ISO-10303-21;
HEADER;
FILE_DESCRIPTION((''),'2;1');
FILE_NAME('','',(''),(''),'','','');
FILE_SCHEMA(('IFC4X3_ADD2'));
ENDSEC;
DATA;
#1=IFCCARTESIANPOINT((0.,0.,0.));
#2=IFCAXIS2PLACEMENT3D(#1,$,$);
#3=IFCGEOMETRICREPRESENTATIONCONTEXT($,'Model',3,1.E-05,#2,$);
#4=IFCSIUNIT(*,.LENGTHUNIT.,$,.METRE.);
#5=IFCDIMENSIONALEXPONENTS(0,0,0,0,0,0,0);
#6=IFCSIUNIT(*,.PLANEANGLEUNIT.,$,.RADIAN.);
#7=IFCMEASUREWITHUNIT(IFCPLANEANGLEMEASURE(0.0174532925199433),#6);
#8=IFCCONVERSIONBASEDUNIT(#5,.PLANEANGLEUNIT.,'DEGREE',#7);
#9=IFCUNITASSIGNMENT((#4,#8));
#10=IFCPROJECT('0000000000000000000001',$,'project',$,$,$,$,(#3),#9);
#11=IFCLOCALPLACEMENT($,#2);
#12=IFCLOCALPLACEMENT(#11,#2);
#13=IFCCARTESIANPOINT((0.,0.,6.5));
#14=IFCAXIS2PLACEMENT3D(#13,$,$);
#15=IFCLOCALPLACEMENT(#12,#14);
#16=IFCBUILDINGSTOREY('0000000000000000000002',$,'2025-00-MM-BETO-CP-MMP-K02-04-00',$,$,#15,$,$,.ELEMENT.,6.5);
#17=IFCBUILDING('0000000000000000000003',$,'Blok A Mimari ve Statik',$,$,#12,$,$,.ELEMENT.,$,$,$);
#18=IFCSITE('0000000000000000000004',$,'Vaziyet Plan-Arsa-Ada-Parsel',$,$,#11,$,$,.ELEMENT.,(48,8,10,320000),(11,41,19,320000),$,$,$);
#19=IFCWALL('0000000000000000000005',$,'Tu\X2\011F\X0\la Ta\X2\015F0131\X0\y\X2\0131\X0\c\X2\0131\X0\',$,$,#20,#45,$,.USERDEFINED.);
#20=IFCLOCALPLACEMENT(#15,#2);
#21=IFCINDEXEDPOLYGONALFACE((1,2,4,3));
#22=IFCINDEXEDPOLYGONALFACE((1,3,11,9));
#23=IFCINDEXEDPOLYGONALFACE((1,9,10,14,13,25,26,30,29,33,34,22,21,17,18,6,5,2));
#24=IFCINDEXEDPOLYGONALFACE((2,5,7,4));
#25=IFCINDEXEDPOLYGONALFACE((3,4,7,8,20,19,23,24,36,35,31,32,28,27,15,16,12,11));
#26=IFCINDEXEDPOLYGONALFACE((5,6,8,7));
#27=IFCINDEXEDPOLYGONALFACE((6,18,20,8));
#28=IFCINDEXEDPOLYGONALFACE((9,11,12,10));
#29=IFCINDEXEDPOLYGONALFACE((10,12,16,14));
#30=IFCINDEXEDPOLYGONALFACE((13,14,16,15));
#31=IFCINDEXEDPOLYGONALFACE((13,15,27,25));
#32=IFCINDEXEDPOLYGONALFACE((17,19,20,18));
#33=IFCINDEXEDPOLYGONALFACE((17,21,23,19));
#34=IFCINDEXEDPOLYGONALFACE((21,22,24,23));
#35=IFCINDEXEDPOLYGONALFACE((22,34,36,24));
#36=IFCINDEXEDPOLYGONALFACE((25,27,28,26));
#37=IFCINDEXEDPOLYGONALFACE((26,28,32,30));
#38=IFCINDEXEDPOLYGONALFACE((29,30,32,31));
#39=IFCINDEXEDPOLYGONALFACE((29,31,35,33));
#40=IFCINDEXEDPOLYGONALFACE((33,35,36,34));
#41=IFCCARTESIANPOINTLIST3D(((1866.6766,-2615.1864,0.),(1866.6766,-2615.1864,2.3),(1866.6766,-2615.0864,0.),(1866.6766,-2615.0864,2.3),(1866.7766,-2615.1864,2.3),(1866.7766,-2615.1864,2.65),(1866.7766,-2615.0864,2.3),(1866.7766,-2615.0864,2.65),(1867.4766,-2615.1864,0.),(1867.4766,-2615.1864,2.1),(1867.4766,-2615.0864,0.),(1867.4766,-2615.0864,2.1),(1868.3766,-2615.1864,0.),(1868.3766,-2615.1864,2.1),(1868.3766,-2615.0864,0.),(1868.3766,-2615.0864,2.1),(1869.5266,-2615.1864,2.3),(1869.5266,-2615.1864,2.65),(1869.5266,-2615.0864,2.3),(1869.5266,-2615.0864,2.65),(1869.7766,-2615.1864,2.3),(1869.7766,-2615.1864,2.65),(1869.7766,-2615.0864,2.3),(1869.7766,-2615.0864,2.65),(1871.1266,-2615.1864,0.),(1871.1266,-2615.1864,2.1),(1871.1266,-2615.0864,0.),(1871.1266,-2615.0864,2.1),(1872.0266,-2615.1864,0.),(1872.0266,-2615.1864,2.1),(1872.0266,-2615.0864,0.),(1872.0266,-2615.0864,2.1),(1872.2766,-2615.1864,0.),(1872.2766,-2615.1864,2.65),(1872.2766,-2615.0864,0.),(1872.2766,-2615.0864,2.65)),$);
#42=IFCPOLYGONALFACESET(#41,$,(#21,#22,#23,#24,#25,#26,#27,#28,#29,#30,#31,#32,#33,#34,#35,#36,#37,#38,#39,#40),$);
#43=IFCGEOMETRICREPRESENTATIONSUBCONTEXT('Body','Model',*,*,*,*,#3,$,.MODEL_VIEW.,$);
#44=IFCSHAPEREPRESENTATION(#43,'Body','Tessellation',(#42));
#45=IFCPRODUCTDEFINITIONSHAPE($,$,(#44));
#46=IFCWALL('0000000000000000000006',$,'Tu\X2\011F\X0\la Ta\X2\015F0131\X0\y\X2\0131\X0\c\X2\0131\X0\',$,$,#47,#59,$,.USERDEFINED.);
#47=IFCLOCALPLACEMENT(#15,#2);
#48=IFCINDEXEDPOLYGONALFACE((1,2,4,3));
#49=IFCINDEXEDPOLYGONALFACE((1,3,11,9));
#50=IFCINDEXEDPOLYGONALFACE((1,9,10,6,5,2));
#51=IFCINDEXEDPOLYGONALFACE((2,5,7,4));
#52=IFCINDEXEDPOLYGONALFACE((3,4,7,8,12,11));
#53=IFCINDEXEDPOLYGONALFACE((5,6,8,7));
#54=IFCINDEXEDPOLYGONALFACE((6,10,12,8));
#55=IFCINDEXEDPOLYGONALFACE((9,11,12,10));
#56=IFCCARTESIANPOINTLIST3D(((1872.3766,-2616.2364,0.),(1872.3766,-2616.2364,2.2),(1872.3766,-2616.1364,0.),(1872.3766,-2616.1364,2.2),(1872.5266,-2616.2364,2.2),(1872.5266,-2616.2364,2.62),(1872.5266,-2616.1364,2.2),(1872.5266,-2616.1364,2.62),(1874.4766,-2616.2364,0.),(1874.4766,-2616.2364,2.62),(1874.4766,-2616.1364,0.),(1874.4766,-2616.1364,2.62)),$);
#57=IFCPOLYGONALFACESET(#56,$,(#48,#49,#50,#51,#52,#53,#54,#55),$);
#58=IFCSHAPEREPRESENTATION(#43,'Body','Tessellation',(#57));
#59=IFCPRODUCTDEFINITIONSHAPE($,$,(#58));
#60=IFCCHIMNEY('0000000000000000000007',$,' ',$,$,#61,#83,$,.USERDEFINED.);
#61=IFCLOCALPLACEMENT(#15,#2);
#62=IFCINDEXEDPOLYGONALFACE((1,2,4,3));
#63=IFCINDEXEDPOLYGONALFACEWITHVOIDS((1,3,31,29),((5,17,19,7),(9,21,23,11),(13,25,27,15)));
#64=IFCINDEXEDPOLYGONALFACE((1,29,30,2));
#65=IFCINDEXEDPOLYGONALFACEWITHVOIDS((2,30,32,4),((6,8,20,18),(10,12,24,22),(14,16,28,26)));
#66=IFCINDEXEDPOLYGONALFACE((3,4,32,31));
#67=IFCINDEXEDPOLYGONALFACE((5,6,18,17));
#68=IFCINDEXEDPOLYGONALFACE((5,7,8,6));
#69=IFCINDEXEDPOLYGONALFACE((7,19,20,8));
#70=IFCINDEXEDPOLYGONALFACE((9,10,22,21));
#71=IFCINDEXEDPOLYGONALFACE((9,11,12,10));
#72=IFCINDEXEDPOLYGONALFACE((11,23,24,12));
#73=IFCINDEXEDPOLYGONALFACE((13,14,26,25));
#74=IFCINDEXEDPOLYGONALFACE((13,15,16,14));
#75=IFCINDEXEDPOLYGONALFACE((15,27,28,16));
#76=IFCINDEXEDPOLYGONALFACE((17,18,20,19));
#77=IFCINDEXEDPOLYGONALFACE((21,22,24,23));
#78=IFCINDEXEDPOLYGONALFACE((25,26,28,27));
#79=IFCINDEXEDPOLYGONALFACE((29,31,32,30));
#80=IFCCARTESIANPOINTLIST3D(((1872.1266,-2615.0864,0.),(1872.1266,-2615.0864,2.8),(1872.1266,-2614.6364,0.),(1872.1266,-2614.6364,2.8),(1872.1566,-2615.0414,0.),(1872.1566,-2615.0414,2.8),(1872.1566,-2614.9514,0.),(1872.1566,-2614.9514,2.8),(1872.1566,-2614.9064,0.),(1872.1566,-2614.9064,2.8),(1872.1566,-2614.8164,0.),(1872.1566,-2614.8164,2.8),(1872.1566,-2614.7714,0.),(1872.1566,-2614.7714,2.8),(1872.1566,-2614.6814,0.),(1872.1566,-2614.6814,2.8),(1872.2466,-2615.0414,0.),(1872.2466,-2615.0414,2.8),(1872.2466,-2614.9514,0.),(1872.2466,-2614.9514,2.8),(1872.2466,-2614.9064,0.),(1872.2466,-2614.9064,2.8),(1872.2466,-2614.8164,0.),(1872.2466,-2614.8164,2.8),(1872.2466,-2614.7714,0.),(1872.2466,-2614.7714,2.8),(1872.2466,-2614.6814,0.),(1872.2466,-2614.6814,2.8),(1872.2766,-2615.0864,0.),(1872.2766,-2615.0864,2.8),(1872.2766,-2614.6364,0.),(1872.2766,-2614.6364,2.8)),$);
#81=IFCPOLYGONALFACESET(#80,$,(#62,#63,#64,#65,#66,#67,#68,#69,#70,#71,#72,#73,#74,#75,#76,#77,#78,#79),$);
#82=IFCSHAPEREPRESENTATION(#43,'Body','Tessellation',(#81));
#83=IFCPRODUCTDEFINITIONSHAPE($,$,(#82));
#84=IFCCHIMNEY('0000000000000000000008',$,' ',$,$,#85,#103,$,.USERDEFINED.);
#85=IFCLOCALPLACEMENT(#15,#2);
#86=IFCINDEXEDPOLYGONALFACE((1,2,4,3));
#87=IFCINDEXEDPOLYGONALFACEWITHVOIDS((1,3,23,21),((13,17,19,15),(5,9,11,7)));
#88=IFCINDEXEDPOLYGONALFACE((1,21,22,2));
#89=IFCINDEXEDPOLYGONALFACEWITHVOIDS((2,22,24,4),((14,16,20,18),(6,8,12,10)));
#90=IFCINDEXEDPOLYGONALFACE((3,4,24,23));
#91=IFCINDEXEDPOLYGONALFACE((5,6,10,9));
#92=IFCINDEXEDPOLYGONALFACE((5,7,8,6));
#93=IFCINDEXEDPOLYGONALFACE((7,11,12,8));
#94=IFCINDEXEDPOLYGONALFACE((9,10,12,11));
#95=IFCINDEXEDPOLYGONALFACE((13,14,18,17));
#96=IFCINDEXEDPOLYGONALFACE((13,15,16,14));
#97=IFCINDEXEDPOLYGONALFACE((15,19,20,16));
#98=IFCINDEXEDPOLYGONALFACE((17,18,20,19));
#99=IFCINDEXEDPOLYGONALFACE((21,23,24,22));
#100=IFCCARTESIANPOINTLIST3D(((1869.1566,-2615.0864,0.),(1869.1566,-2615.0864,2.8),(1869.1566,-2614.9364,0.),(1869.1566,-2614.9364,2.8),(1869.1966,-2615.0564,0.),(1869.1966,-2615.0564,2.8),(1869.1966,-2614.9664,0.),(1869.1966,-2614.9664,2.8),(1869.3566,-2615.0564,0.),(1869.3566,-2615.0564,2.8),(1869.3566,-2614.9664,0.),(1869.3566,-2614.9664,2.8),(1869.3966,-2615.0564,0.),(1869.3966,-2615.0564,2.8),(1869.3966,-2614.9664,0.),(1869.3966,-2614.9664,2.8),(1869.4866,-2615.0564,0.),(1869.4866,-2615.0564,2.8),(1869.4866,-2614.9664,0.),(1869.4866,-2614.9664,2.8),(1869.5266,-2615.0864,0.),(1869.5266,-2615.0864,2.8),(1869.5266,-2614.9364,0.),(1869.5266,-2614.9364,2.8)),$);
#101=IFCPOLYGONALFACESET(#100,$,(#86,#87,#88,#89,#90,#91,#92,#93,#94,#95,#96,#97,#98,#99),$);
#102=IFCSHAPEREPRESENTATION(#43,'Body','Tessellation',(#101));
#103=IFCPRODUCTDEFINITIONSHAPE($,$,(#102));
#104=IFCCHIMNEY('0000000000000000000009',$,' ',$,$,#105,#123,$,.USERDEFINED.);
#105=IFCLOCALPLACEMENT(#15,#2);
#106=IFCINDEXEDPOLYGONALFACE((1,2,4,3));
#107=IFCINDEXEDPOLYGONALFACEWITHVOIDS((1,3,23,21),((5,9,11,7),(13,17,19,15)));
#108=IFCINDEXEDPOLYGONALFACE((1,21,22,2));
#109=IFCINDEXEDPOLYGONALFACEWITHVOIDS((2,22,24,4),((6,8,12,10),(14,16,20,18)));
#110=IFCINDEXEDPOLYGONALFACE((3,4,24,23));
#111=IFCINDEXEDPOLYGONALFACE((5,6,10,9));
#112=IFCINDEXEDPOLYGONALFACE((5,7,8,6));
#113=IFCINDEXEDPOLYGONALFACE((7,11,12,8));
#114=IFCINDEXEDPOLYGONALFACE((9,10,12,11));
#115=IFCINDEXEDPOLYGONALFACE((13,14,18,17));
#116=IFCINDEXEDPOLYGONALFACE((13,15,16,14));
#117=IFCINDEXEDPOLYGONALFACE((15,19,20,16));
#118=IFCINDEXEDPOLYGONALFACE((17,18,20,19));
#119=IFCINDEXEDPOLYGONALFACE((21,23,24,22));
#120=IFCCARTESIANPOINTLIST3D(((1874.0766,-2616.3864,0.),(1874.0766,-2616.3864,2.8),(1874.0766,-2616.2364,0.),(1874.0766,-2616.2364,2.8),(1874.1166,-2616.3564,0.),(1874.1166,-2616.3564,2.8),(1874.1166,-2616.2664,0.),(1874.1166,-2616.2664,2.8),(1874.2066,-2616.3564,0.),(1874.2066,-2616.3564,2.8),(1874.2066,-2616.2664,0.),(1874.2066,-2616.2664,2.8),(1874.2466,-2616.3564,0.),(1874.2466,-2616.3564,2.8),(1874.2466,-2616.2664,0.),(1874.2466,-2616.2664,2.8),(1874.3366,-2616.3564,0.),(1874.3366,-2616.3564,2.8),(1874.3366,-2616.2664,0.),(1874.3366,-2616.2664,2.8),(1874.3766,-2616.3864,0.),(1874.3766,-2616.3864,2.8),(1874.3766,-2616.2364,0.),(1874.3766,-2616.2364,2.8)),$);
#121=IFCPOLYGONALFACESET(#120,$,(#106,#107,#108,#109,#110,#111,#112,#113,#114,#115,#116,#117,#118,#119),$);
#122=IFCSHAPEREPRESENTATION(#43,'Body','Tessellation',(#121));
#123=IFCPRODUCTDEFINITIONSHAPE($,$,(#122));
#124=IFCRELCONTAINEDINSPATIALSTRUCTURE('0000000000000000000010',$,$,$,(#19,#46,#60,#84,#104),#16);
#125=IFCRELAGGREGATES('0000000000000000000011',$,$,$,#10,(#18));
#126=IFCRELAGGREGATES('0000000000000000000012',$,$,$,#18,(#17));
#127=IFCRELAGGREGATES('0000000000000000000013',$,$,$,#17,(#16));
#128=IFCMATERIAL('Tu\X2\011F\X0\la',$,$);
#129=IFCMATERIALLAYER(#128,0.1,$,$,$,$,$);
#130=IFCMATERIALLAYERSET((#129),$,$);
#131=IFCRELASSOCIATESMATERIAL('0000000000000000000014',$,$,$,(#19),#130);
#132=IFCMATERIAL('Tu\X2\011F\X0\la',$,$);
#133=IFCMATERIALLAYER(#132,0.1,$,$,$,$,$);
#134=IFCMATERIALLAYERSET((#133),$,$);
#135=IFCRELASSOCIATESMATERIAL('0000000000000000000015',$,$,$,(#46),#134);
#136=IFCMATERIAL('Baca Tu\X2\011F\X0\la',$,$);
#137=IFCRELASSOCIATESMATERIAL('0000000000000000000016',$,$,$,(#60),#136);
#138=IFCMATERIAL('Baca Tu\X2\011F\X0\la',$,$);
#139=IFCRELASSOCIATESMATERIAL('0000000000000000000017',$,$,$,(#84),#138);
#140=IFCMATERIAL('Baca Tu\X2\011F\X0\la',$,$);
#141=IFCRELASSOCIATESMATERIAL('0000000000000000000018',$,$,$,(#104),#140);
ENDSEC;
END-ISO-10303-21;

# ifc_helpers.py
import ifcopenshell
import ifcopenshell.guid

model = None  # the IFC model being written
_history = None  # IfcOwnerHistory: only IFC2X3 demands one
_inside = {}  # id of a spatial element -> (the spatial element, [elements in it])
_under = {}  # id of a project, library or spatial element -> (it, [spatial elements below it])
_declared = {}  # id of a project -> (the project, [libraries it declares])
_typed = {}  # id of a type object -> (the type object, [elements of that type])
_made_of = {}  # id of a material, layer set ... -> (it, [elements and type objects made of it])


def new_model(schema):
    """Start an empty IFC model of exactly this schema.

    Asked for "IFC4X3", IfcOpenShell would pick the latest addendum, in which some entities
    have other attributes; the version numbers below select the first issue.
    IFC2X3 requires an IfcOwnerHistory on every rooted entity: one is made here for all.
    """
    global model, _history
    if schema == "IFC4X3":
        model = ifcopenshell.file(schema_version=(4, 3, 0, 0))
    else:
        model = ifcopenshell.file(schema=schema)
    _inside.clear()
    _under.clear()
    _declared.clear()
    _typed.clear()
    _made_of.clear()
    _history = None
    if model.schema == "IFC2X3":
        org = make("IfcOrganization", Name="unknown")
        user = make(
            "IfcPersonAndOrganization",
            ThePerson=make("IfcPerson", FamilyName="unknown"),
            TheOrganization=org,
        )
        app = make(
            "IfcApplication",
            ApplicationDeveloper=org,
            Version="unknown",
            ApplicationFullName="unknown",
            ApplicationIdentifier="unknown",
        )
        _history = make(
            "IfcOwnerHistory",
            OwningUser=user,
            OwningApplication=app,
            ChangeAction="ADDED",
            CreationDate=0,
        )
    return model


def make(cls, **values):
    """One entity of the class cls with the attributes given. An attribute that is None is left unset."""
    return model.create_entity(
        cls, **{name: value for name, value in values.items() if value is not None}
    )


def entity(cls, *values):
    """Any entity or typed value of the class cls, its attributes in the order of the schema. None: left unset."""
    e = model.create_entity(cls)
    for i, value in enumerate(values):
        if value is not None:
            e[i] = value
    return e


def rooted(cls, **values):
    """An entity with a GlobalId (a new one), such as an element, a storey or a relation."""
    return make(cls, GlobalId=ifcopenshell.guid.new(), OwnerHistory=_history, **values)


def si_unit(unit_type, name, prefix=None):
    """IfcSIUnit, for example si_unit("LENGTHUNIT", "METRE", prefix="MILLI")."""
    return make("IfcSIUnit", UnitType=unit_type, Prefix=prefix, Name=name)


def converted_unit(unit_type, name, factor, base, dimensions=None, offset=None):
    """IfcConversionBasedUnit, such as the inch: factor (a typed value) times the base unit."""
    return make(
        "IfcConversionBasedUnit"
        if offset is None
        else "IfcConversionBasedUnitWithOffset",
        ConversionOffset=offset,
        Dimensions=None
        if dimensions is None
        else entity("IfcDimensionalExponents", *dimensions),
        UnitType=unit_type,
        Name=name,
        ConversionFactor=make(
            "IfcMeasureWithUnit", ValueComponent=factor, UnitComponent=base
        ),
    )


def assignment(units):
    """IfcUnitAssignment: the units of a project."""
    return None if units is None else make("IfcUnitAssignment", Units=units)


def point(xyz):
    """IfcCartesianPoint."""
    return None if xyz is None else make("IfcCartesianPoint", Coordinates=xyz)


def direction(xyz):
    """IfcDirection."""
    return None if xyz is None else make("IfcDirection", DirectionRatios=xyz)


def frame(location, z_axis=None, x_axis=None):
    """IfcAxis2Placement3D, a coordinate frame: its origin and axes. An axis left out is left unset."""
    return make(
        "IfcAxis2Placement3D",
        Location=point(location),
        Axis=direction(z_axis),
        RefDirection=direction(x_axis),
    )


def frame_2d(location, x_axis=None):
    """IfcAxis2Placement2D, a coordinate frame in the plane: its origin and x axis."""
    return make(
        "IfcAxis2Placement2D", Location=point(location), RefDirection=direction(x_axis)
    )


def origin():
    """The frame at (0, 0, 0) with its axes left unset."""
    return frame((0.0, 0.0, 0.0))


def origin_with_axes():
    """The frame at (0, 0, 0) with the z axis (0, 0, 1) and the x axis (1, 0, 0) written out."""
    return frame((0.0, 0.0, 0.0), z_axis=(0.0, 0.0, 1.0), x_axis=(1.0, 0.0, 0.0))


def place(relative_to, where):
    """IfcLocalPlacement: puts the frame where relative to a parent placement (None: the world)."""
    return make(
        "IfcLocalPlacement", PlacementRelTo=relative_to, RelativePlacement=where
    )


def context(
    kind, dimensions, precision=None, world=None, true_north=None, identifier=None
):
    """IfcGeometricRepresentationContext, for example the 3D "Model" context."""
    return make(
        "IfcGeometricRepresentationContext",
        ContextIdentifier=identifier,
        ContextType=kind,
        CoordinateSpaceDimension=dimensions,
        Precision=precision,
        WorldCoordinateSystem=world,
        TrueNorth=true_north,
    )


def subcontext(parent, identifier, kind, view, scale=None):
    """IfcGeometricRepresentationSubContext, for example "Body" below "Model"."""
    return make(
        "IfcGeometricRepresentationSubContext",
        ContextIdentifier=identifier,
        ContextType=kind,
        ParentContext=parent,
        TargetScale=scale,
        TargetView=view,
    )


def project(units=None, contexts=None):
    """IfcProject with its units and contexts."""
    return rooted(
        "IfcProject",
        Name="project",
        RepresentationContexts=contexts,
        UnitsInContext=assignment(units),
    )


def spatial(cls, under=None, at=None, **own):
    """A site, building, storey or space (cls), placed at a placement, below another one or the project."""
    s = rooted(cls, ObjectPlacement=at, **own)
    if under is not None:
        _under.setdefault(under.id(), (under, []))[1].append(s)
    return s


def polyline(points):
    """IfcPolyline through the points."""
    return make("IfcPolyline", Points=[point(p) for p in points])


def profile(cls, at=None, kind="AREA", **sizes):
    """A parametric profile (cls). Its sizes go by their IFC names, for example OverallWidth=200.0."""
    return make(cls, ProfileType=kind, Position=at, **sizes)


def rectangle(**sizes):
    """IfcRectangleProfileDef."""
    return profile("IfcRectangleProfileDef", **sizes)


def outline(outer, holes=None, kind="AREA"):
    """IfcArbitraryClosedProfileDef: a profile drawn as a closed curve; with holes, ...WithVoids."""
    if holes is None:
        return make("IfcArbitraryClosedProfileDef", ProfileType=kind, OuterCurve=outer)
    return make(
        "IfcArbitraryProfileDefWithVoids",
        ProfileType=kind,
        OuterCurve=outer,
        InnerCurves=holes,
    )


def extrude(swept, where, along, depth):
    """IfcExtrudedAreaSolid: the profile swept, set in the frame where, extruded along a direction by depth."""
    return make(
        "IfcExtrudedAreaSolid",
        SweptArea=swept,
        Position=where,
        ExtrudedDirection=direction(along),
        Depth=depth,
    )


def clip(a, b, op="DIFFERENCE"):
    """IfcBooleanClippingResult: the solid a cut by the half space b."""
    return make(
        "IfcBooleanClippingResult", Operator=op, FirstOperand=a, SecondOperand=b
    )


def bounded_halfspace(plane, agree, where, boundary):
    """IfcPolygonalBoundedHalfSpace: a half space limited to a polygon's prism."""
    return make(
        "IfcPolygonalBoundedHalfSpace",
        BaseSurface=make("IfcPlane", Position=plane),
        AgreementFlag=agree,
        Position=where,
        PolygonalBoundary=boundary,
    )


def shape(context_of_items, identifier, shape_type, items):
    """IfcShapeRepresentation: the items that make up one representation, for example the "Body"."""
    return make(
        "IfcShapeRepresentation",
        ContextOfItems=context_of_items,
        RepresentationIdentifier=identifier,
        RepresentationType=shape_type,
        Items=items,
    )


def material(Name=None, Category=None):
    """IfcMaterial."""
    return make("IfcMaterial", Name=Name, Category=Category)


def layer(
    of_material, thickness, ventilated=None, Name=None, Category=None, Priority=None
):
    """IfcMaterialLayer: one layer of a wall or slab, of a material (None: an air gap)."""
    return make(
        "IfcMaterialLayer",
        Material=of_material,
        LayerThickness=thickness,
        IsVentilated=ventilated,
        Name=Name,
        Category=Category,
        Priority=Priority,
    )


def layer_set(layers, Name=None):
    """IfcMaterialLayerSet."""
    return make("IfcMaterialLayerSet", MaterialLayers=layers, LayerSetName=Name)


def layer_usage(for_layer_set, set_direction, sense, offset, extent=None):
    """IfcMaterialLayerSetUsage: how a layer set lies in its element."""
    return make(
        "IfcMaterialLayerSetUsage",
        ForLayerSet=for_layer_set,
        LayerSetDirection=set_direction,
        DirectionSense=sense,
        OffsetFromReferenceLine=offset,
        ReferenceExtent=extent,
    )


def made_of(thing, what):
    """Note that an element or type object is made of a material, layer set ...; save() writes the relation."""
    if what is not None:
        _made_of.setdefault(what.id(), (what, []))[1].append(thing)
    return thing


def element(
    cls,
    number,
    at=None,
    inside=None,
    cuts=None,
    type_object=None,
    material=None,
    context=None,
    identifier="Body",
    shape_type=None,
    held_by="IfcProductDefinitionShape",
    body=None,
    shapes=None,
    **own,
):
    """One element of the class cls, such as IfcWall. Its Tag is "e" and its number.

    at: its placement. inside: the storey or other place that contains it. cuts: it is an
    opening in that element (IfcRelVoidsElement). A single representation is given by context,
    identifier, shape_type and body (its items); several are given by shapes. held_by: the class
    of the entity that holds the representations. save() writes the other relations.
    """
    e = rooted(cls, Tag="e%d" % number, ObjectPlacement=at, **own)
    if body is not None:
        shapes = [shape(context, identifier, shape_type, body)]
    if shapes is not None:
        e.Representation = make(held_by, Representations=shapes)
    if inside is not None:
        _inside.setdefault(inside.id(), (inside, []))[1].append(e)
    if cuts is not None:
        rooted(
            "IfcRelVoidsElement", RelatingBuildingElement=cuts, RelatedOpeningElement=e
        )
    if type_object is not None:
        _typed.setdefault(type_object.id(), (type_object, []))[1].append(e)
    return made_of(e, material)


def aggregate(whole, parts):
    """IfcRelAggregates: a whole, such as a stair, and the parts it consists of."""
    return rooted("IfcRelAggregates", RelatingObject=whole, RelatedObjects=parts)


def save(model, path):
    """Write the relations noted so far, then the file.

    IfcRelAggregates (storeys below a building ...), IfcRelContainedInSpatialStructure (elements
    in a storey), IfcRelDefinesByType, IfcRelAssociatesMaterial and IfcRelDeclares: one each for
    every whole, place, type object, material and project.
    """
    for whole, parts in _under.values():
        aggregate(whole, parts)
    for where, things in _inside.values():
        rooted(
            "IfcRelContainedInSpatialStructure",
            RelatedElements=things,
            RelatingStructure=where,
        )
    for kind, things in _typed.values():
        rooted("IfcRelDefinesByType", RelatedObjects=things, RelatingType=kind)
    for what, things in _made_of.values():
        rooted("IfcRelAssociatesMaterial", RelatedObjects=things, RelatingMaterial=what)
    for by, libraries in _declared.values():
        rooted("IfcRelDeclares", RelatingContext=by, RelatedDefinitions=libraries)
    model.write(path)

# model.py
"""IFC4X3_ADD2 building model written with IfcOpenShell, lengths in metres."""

from ifc_helpers import new_model, entity, si_unit, converted_unit, frame, frame_2d, origin, origin_with_axes, place, context, subcontext, project, spatial, polyline, rectangle, outline, extrude, clip, bounded_halfspace, material, layer, layer_set, layer_usage, element, save


model = new_model("IFC4X3_ADD2")

# Units and contexts
model_context = context("Model", 3, precision=1e-05, world=origin())
body_context = subcontext(model_context, "Body", "Model", "MODEL_VIEW")
ifc_project = project(units=[si_unit("LENGTHUNIT", "METRE"), converted_unit("PLANEANGLEUNIT", "DEGREE", entity("IfcPlaneAngleMeasure", 0.0174532925199433), si_unit("PLANEANGLEUNIT", "RADIAN"), dimensions=[0, 0, 0, 0, 0, 0, 0])], contexts=[model_context])

# Site, building, storey
site_placement = place(None, origin())
site = spatial("IfcSite", under=ifc_project, at=site_placement, Name="Vaziyet Plan-Arsa-Ada-Parsel", CompositionType="ELEMENT", RefLatitude=(48, 8, 10, 320000), RefLongitude=(11, 41, 19, 320000))
building_placement = place(site_placement, origin())
building = spatial("IfcBuilding", under=site, at=building_placement, Name="Blok A Mimari ve Statik", CompositionType="ELEMENT")
storey_placement = place(building_placement, frame((0.0, 0.0, 6.5)))
storey = spatial("IfcBuildingStorey", under=building, at=storey_placement, Name="2025-00-MM-BETO-CP-MMP-K02-04-00", CompositionType="ELEMENT", Elevation=6.5)

# Wall, openings
ifc_material_1 = material(Name="Tuğla")
ifc_layer_1 = layer(ifc_material_1, 0.1)
ifc_layer_set_1 = layer_set([ifc_layer_1])
ifc_layer_usage_1 = layer_usage(ifc_layer_set_1, "AXIS2", "POSITIVE", 0.0)
wall_1_placement = place(storey_placement, frame((1872.2766, -2615.0864, 0.0), z_axis=(0.0, 0.0, 1.0), x_axis=(-1.0, 0.0, 0.0)))
wall_1 = element("IfcWall", 1, at=wall_1_placement, inside=storey, material=ifc_layer_usage_1, Name="Tuğla Taşıyıcı", PredefinedType="USERDEFINED", context=body_context, shape_type="Clipping", body=[
    clip(clip(extrude(rectangle(XDim=5.6, YDim=0.1, at=frame_2d((2.8, 0.05), x_axis=(1.0, 0.0))), origin_with_axes(), (0.0, 0.0, 1.0), 2.65), bounded_halfspace(frame((5.55, 0.05, 2.3), z_axis=(0.0, 0.0, -1.0), x_axis=(0.0, -1.0, 0.0)), True, origin_with_axes(), polyline([(5.5, 0.1), (5.5, 0.0), (5.6, 0.0), (5.6, 0.1), (5.5, 0.1)]))), bounded_halfspace(frame((2.625, 0.05, 2.3), z_axis=(0.0, 0.0, -1.0), x_axis=(0.0, -1.0, 0.0)), True, origin_with_axes(), polyline([(2.5, 0.1), (2.5, 0.0), (2.75, 0.0), (2.75, 0.1), (2.5, 0.1)]))),
])
opening_1_placement = place(wall_1_placement, frame((4.8, 0.1, 0.0), z_axis=(0.0, -1.0, 0.0), x_axis=(0.0, 0.0, 1.0)))
element("IfcOpeningElement", 2, at=opening_1_placement, cuts=wall_1, PredefinedType="OPENING", context=body_context, shape_type="SweptSolid", body=[
    extrude(outline(polyline([(2.1, 0.9), (2.1, 0.0), (0.0, 0.0), (0.0, 0.9), (2.1, 0.9)])), origin_with_axes(), (0.0, 0.0, 1.0), 0.1),
])
opening_2_placement = place(wall_1_placement, frame((1.15, 0.1, 0.0), z_axis=(0.0, -1.0, 0.0), x_axis=(0.0, 0.0, 1.0)))
element("IfcOpeningElement", 3, at=opening_2_placement, cuts=wall_1, PredefinedType="OPENING", context=body_context, shape_type="SweptSolid", body=[
    extrude(outline(polyline([(2.1, 0.9), (2.1, 0.0), (0.0, 0.0), (0.0, 0.9), (2.1, 0.9)])), origin_with_axes(), (0.0, 0.0, 1.0), 0.1),
])

# Wall
ifc_material_2 = material(Name="Tuğla")
ifc_layer_2 = layer(ifc_material_2, 0.1)
ifc_layer_set_2 = layer_set([ifc_layer_2])
ifc_layer_usage_2 = layer_usage(ifc_layer_set_2, "AXIS2", "POSITIVE", 0.0)
wall_2_placement = place(storey_placement, frame((1872.3766, -2616.2364, 0.0), z_axis=(0.0, 0.0, 1.0), x_axis=(1.0, 0.0, 0.0)))
element("IfcWall", 4, at=wall_2_placement, inside=storey, material=ifc_layer_usage_2, Name="Tuğla Taşıyıcı", PredefinedType="USERDEFINED", context=body_context, shape_type="Clipping", body=[
    clip(extrude(rectangle(XDim=2.1, YDim=0.1, at=frame_2d((1.05, 0.05), x_axis=(1.0, 0.0))), origin_with_axes(), (0.0, 0.0, 1.0), 2.62), bounded_halfspace(frame((0.075, 0.05, 2.2), z_axis=(0.0, 0.0, -1.0), x_axis=(0.0, -1.0, 0.0)), True, origin_with_axes(), polyline([(0.0, 0.1), (0.0, 0.0), (0.15, 0.0), (0.15, 0.1), (0.0, 0.1)]))),
])

# Chimneys
ifc_material_3 = material(Name="Baca Tuğla")
chimney_1_placement = place(storey_placement, frame((1872.1266, -2615.0864, 0.0)))
element("IfcChimney", 5, at=chimney_1_placement, inside=storey, material=ifc_material_3, Name=" ", PredefinedType="USERDEFINED", context=body_context, shape_type="SweptSolid", body=[
    extrude(outline(polyline([(0.15, 0.0), (0.15, 0.45), (0.0, 0.45), (0.0, 0.0), (0.15, 0.0)]), holes=[polyline([(0.12, 0.18), (0.03, 0.18), (0.03, 0.27), (0.12, 0.27), (0.12, 0.18)]), polyline([(0.12, 0.315), (0.03, 0.315), (0.03, 0.405), (0.12, 0.405), (0.12, 0.315)]), polyline([(0.12, 0.045), (0.03, 0.045), (0.03, 0.135), (0.12, 0.135), (0.12, 0.045)])]), origin_with_axes(), (0.0, 0.0, 1.0), 2.8),
])
ifc_material_4 = material(Name="Baca Tuğla")
chimney_2_placement = place(storey_placement, frame((1869.1566, -2615.0864, 0.0)))
element("IfcChimney", 6, at=chimney_2_placement, inside=storey, material=ifc_material_4, Name=" ", PredefinedType="USERDEFINED", context=body_context, shape_type="SweptSolid", body=[
    extrude(outline(polyline([(0.0, 0.0), (0.37, 0.0), (0.37, 0.15), (0.0, 0.15), (0.0, 0.0)]), holes=[polyline([(0.24, 0.03), (0.24, 0.12), (0.33, 0.12), (0.33, 0.03), (0.24, 0.03)]), polyline([(0.04, 0.03), (0.04, 0.12), (0.2, 0.12), (0.2, 0.03), (0.04, 0.03)])]), origin_with_axes(), (0.0, 0.0, 1.0), 2.8),
])
ifc_material_5 = material(Name="Baca Tuğla")
chimney_3_placement = place(storey_placement, frame((1874.0766, -2616.3864, 0.0)))
element("IfcChimney", 7, at=chimney_3_placement, inside=storey, material=ifc_material_5, Name=" ", PredefinedType="USERDEFINED", context=body_context, shape_type="SweptSolid", body=[
    extrude(outline(polyline([(0.3, 0.15), (0.0, 0.15), (0.0, 0.0), (0.3, 0.0), (0.3, 0.15)]), holes=[polyline([(0.13, 0.12), (0.13, 0.03), (0.04, 0.03), (0.04, 0.12), (0.13, 0.12)]), polyline([(0.26, 0.12), (0.26, 0.03), (0.17, 0.03), (0.17, 0.12), (0.26, 0.12)])]), origin_with_axes(), (0.0, 0.0, 1.0), 2.8),
])

save(model, "model.ifc")
